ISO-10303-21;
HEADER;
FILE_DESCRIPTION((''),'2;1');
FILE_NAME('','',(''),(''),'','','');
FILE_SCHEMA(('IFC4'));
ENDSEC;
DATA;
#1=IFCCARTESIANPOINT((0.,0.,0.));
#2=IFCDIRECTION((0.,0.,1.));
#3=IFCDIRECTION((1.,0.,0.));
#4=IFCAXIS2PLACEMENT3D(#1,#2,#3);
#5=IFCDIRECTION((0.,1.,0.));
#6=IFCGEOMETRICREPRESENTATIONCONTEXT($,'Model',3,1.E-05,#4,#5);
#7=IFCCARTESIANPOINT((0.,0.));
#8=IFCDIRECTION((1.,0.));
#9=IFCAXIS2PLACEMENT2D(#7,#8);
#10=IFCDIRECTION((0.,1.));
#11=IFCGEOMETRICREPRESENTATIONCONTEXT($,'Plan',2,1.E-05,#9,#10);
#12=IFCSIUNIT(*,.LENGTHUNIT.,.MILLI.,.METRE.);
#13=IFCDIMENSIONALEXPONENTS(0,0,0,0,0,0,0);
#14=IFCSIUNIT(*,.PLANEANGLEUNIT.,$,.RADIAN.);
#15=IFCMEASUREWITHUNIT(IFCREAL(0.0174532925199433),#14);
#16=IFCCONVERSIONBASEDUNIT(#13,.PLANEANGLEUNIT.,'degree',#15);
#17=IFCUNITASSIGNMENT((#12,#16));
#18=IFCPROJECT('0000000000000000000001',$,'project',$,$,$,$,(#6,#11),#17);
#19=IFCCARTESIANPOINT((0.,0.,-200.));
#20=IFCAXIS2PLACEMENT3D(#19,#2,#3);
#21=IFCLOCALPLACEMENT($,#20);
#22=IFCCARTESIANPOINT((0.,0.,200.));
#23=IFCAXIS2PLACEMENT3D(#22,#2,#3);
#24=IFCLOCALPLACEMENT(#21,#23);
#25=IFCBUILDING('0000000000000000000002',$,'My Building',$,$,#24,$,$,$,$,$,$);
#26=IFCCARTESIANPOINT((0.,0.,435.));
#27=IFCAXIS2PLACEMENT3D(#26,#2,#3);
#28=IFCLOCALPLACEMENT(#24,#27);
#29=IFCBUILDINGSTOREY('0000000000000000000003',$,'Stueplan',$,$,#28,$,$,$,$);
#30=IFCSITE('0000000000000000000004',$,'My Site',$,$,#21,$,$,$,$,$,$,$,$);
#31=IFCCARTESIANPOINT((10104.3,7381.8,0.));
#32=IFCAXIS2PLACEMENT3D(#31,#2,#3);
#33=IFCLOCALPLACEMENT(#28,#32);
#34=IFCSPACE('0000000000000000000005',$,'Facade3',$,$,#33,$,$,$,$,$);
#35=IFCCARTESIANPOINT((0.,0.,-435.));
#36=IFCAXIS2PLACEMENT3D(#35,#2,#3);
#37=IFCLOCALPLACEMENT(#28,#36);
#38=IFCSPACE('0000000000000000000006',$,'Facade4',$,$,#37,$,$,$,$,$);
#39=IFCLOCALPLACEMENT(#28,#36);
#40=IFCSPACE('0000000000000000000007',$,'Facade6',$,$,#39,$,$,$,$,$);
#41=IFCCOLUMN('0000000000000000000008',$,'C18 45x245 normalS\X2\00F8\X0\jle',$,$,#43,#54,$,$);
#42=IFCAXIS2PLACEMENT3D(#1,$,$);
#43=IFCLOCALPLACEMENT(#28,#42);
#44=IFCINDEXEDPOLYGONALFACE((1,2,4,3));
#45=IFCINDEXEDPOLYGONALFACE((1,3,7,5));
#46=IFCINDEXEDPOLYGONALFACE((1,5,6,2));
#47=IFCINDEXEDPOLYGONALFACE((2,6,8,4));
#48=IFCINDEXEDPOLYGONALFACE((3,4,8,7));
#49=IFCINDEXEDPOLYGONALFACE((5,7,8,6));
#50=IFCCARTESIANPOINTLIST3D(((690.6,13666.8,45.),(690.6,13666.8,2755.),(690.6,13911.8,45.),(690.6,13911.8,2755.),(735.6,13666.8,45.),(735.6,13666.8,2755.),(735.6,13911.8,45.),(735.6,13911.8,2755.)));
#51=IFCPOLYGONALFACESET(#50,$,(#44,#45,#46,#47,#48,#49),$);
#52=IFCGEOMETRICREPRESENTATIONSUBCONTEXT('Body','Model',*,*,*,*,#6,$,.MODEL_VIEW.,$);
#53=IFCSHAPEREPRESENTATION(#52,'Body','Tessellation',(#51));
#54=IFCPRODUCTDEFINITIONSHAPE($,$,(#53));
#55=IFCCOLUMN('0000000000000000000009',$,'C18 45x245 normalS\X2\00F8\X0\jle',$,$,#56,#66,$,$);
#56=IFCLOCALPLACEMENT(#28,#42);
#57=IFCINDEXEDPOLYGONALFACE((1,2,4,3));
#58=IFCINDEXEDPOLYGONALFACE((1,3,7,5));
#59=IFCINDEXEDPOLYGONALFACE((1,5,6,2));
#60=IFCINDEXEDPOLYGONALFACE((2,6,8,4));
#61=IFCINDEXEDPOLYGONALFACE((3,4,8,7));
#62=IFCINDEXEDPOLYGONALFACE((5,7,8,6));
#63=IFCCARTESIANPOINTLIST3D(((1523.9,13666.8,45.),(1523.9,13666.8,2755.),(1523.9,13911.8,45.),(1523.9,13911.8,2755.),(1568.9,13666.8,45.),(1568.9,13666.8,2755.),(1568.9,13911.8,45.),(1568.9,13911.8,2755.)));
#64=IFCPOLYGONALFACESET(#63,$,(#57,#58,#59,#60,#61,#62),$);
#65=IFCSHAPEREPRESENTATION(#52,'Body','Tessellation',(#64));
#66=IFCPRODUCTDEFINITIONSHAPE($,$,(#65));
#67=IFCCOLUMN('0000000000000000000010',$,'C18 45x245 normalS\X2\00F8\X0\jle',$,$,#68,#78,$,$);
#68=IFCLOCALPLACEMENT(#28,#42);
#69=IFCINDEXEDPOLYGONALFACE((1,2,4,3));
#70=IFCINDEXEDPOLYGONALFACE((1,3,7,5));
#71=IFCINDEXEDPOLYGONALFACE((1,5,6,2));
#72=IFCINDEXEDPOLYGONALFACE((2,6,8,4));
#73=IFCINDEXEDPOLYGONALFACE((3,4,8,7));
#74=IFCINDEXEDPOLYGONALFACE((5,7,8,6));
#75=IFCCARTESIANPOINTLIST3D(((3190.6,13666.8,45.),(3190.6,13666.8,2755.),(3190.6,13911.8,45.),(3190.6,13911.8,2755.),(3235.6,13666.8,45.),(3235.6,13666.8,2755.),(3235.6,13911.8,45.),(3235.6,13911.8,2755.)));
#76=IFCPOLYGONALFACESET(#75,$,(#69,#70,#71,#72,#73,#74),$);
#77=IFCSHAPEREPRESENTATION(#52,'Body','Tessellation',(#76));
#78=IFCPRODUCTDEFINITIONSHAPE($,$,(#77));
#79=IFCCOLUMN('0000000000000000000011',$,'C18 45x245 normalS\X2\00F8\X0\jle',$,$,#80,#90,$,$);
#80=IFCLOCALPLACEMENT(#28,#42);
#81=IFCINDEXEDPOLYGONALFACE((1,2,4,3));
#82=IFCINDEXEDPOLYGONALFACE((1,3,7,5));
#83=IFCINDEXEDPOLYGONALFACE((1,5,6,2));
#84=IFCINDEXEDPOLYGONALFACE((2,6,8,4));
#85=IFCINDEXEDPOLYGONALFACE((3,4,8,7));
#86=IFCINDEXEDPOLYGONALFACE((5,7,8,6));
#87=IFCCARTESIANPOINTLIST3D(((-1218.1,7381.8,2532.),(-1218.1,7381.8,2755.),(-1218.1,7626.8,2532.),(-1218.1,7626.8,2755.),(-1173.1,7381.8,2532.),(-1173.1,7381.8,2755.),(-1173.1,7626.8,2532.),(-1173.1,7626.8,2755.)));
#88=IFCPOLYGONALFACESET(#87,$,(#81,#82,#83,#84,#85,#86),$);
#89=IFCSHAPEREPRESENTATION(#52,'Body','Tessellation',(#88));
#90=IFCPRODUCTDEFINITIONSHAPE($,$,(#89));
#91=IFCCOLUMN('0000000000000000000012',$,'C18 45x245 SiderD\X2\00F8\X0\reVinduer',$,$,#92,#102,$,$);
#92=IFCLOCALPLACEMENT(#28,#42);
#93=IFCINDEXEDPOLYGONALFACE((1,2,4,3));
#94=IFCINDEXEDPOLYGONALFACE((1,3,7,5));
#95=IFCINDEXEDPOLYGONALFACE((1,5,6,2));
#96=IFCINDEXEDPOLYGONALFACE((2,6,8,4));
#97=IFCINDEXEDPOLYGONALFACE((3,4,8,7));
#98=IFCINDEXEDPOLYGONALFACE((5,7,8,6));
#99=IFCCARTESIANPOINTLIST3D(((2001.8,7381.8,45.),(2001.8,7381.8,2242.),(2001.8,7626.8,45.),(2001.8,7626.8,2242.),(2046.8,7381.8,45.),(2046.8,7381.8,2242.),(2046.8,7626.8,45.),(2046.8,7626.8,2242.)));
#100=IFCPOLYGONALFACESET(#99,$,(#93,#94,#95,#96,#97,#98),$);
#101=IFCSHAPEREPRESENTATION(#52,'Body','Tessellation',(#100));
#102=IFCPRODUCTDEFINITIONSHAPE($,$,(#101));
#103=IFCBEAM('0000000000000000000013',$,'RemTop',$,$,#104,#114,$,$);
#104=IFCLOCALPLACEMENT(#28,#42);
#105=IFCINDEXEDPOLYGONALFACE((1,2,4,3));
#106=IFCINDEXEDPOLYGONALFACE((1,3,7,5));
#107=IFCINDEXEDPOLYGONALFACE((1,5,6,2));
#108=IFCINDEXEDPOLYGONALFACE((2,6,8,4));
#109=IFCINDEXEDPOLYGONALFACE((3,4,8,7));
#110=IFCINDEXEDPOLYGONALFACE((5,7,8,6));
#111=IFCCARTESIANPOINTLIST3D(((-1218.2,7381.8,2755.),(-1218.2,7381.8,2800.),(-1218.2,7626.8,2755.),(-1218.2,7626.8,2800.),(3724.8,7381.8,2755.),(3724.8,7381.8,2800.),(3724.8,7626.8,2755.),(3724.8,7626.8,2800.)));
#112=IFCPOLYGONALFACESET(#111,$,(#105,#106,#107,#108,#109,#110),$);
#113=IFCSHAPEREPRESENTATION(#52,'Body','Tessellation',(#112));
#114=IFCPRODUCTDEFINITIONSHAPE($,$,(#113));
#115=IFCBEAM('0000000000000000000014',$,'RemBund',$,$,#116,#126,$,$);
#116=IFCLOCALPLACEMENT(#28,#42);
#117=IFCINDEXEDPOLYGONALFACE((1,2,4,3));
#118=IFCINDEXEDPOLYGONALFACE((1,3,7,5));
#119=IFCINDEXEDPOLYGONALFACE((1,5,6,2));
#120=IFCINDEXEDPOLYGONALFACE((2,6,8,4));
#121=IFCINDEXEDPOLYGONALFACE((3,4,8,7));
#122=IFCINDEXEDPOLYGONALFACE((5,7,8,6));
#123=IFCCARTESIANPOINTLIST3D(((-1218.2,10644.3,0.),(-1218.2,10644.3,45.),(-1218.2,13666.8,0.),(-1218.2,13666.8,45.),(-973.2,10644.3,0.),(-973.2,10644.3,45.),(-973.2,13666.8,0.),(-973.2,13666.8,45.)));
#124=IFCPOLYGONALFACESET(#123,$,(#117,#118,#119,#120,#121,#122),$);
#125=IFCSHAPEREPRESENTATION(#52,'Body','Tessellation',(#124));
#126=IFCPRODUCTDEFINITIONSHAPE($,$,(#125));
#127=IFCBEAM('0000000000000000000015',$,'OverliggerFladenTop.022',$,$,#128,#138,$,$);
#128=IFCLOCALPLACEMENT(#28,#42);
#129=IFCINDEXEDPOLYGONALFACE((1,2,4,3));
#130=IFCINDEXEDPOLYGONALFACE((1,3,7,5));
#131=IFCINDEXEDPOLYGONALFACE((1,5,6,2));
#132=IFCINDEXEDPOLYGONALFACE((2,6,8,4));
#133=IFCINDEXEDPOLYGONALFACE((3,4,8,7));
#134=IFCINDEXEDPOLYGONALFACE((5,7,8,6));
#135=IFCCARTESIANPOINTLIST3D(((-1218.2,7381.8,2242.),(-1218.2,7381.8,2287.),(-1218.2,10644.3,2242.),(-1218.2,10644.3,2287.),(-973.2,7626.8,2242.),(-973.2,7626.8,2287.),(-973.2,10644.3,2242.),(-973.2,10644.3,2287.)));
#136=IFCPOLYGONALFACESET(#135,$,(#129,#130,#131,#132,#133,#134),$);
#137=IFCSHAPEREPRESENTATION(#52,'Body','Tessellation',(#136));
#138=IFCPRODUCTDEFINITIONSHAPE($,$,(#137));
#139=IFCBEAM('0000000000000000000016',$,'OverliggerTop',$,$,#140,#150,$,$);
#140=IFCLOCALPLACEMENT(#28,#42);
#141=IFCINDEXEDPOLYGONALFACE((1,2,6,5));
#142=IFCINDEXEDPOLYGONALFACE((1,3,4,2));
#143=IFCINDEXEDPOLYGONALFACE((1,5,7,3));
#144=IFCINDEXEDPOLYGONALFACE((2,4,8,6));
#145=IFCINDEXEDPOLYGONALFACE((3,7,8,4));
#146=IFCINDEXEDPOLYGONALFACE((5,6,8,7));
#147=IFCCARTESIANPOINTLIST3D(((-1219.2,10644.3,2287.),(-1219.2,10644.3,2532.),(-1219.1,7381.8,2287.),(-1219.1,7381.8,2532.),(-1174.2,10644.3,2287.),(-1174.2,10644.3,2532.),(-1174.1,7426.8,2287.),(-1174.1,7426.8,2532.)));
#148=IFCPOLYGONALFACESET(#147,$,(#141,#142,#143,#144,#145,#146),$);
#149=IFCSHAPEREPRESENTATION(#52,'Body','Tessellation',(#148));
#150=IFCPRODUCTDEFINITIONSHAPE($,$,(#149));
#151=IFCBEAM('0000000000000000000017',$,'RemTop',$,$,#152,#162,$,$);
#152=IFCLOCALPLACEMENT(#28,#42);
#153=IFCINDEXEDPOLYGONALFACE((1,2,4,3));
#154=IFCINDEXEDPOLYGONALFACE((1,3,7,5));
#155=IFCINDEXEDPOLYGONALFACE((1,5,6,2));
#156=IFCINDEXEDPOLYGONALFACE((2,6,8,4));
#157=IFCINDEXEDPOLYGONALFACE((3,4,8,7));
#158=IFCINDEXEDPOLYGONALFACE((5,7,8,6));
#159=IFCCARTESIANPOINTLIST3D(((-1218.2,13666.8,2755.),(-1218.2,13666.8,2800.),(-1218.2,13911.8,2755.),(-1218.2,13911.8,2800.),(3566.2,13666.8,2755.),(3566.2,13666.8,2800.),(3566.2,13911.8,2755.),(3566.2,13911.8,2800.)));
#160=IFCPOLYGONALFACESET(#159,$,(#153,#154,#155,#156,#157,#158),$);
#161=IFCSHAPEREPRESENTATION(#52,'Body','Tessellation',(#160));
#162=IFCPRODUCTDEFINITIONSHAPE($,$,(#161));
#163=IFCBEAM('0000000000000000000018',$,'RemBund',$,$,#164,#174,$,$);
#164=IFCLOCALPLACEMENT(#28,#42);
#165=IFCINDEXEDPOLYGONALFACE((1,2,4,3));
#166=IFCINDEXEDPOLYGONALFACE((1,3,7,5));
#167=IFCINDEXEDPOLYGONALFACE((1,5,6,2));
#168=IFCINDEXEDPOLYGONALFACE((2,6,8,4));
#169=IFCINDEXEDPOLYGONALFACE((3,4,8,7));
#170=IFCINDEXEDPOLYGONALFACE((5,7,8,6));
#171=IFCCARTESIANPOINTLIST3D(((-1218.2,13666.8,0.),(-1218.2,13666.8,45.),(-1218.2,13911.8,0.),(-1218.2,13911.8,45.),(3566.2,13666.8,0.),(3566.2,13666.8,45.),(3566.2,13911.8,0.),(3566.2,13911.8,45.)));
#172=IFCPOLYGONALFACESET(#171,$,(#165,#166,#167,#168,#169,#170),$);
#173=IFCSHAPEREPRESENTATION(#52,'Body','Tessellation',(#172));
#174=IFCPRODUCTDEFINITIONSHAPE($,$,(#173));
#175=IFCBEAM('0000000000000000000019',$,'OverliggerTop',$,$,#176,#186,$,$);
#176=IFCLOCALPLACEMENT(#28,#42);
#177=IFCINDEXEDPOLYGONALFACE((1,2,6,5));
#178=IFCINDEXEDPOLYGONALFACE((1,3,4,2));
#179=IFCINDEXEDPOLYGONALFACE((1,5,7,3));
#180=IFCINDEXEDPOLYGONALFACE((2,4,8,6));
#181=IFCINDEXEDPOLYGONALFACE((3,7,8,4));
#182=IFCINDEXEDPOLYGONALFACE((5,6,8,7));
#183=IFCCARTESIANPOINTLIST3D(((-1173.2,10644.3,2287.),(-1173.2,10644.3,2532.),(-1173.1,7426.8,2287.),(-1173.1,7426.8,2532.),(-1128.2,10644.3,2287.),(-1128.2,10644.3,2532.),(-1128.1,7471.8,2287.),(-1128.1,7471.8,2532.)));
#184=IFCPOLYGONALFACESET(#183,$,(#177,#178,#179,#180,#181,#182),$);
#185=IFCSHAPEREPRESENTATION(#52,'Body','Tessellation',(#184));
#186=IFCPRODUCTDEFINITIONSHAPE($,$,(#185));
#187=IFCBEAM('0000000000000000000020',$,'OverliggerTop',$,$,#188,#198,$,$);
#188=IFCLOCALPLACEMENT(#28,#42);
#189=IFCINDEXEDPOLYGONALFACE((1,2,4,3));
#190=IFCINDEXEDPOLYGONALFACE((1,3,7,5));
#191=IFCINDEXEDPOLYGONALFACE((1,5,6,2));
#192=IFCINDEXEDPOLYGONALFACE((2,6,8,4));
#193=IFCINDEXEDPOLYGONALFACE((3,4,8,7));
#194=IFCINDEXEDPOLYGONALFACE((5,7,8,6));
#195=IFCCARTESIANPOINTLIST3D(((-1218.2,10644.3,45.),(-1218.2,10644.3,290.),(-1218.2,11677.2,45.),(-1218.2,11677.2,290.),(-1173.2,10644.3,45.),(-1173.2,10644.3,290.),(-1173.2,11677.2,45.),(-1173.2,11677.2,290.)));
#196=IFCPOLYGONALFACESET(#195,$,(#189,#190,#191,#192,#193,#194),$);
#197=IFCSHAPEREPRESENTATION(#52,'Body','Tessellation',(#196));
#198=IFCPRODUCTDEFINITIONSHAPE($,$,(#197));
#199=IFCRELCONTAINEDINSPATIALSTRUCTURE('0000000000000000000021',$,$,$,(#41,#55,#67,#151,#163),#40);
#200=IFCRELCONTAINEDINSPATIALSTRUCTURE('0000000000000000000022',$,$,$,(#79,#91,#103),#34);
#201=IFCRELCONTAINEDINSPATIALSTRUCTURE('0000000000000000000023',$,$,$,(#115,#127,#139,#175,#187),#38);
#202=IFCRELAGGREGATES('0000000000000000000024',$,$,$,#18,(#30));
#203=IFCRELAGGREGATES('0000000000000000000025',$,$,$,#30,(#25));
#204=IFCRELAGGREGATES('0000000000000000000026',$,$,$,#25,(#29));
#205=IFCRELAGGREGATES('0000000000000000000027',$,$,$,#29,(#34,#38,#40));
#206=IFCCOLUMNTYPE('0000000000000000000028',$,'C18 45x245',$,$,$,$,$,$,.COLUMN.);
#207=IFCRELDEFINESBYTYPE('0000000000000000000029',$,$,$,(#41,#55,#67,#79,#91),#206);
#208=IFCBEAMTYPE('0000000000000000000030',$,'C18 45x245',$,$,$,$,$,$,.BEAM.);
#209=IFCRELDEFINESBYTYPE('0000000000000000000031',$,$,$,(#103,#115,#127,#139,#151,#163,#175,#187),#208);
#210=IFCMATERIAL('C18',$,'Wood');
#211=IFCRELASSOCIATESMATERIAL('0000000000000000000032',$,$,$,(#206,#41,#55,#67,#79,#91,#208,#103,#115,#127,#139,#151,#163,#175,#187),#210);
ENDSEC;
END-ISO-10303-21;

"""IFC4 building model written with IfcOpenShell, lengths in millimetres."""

from ifc_helpers import new_model, entity, si_unit, converted_unit, direction, frame, origin_with_axes, origin_2d_with_axis, place, context, subcontext, project, spatial, rectangle, extrude, clip, halfspace, material, material_profile, profile_set, profile_usage, type_object, element, save


model = new_model("IFC4")

# Units and contexts
model_context = context("Model", 3, precision=1e-05, world=origin_with_axes(), true_north=direction((0.0, 1.0, 0.0)))
plan_context = context("Plan", 2, precision=1e-05, world=origin_2d_with_axis(), true_north=direction((0.0, 1.0)))
body_context_1 = subcontext(model_context, "Body", "Model", "MODEL_VIEW")
ifc_project = project(units=[si_unit("LENGTHUNIT", "METRE", prefix="MILLI"), converted_unit("PLANEANGLEUNIT", "degree", entity("IfcReal", 0.0174532925199433), si_unit("PLANEANGLEUNIT", "RADIAN"), dimensions=[0, 0, 0, 0, 0, 0, 0])], contexts=[model_context, plan_context])

# Site, building, storey, space
site_placement = place(None, frame((0.0, 0.0, -200.0), z_axis=(0.0, 0.0, 1.0), x_axis=(1.0, 0.0, 0.0)))
site = spatial("IfcSite", under=ifc_project, at=site_placement, Name="My Site")
building_placement = place(site_placement, frame((0.0, 0.0, 200.0), z_axis=(0.0, 0.0, 1.0), x_axis=(1.0, 0.0, 0.0)))
building = spatial("IfcBuilding", under=site, at=building_placement, Name="My Building")
storey_placement = place(building_placement, frame((0.0, 0.0, 435.0), z_axis=(0.0, 0.0, 1.0), x_axis=(1.0, 0.0, 0.0)))
storey = spatial("IfcBuildingStorey", under=building, at=storey_placement, Name="Stueplan")
space_1_placement = place(storey_placement, frame((10104.3, 7381.8, 0.0), z_axis=(0.0, 0.0, 1.0), x_axis=(1.0, 0.0, 0.0)))
space_1 = spatial("IfcSpace", under=storey, at=space_1_placement, Name="Facade3")

# Shared definitions
ifc_material_1 = material(Name="C18", Category="Wood")
ifc_material_profile_1 = material_profile(ifc_material_1, rectangle(XDim=45.0, YDim=245.0))
ifc_profile_set_1 = profile_set([ifc_material_profile_1], Name="woodStructural")
column_type = type_object("IfcColumnType", Name="C18 45x245", PredefinedType="COLUMN", material=ifc_profile_set_1)

# Shared definitions
space_2_placement = place(storey_placement, frame((0.0, 0.0, -435.0), z_axis=(0.0, 0.0, 1.0), x_axis=(1.0, 0.0, 0.0)))
space_2 = spatial("IfcSpace", under=storey, at=space_2_placement, Name="Facade4")

# Shared definitions
space_3_placement = place(storey_placement, frame((0.0, 0.0, -435.0), z_axis=(0.0, 0.0, 1.0), x_axis=(1.0, 0.0, 0.0)))
space_3 = spatial("IfcSpace", under=storey, at=space_3_placement, Name="Facade6")

# Columns
ifc_profile_usage_1 = profile_usage(ifc_profile_set_1, cardinal=9)
column_1_placement = place(space_3_placement, frame((690.6, 13911.8, 480.0), z_axis=(0.0, 0.0, 1.0), x_axis=(1.0, 0.0, 0.0)))
element("IfcColumn", 1, at=column_1_placement, inside=space_3, type_object=column_type, material=ifc_profile_usage_1, Name="C18 45x245 normalSøjle", context=body_context_1, shape_type="SweptSolid", body=[
    extrude(rectangle(XDim=45.0, YDim=245.0), frame((22.5, -122.5, 0.0), z_axis=(0.0, 0.0, 1.0), x_axis=(1.0, 0.0, 0.0)), (0.0, 0.0, 1.0), 2710.0),
])
ifc_profile_usage_2 = profile_usage(ifc_profile_set_1, cardinal=9)
column_2_placement = place(space_3_placement, frame((1523.9, 13911.8, 480.0), z_axis=(0.0, 0.0, 1.0), x_axis=(1.0, 0.0, 0.0)))
element("IfcColumn", 2, at=column_2_placement, inside=space_3, type_object=column_type, material=ifc_profile_usage_2, Name="C18 45x245 normalSøjle", context=body_context_1, shape_type="SweptSolid", body=[
    extrude(rectangle(XDim=45.0, YDim=245.0), frame((22.5, -122.5, 0.0), z_axis=(0.0, 0.0, 1.0), x_axis=(1.0, 0.0, 0.0)), (0.0, 0.0, 1.0), 2710.0),
])
ifc_profile_usage_3 = profile_usage(ifc_profile_set_1, cardinal=9)
column_3_placement = place(space_3_placement, frame((3190.6, 13911.8, 480.0), z_axis=(0.0, 0.0, 1.0), x_axis=(1.0, 0.0, 0.0)))
element("IfcColumn", 3, at=column_3_placement, inside=space_3, type_object=column_type, material=ifc_profile_usage_3, Name="C18 45x245 normalSøjle", context=body_context_1, shape_type="SweptSolid", body=[
    extrude(rectangle(XDim=45.0, YDim=245.0), frame((22.5, -122.5, 0.0), z_axis=(0.0, 0.0, 1.0), x_axis=(1.0, 0.0, 0.0)), (0.0, 0.0, 1.0), 2710.0),
])
ifc_profile_usage_4 = profile_usage(ifc_profile_set_1, cardinal=9)
column_4_placement = place(space_1_placement, frame((-11322.5, 245.0, 2532.0), z_axis=(0.0, 0.0, 1.0), x_axis=(1.0, 0.0, 0.0)))
element("IfcColumn", 4, at=column_4_placement, inside=space_1, type_object=column_type, material=ifc_profile_usage_4, Name="C18 45x245 normalSøjle", context=body_context_1, shape_type="SweptSolid", body=[
    extrude(rectangle(XDim=45.0, YDim=245.0), frame((22.5, -122.5, 0.0), z_axis=(0.0, 0.0, 1.0), x_axis=(1.0, 0.0, 0.0)), (0.0, 0.0, 1.0), 223.0),
])
ifc_profile_usage_5 = profile_usage(ifc_profile_set_1, cardinal=9)
column_5_placement = place(space_1_placement, frame((-8102.5, 245.0, 45.0), z_axis=(0.0, 0.0, 1.0), x_axis=(1.0, 0.0, 0.0)))
element("IfcColumn", 5, at=column_5_placement, inside=space_1, type_object=column_type, material=ifc_profile_usage_5, Name="C18 45x245 SiderDøreVinduer", context=body_context_1, shape_type="SweptSolid", body=[
    extrude(rectangle(XDim=45.0, YDim=245.0), frame((22.5, -122.5, 0.0), z_axis=(0.0, 0.0, 1.0), x_axis=(1.0, 0.0, 0.0)), (0.0, 0.0, 1.0), 2197.0),
])

# Beams
ifc_material_profile_2 = material_profile(ifc_material_1, rectangle(XDim=45.0, YDim=245.0), Name="concrete")
ifc_profile_set_2 = profile_set([ifc_material_profile_2], Name="woodStructural")
ifc_profile_usage_6 = profile_usage(ifc_profile_set_2)
beam_type = type_object("IfcBeamType", Name="C18 45x245", PredefinedType="BEAM", material=ifc_profile_set_2)
beam_1_placement = place(space_1_placement, frame((-6379.6, 122.5, 2777.5), z_axis=(-1.0, 0.0, 0.0), x_axis=(0.0, 0.0, 1.0)))
element("IfcBeam", 6, at=beam_1_placement, inside=space_1, type_object=beam_type, material=ifc_profile_usage_6, Name="RemTop", context=body_context_1, shape_type="SweptSolid", body=[
    extrude(rectangle(XDim=45.0, YDim=245.0), origin_with_axes(), (0.0, 0.0, 1.0), 4942.9),
])
ifc_profile_usage_7 = profile_usage(ifc_profile_set_2)
beam_2_placement = place(space_2_placement, frame((-1095.7, 13666.8, 457.5), z_axis=(0.0, -1.0, 0.0), x_axis=(0.0, 0.0, 1.0)))
element("IfcBeam", 7, at=beam_2_placement, inside=space_2, type_object=beam_type, material=ifc_profile_usage_7, Name="RemBund", context=body_context_1, shape_type="SweptSolid", body=[
    extrude(rectangle(XDim=45.0, YDim=245.0), origin_with_axes(), (0.0, 0.0, 1.0), 3022.5),
])
ifc_profile_usage_8 = profile_usage(ifc_profile_set_2)
beam_3_placement = place(space_2_placement, frame((-1095.7, 10644.3, 2699.5), z_axis=(0.0, -1.0, 0.0), x_axis=(0.0, 0.0, 1.0)))
element("IfcBeam", 8, at=beam_3_placement, inside=space_2, type_object=beam_type, material=ifc_profile_usage_8, Name="OverliggerFladenTop.022", context=body_context_1, shape_type="Clipping", body=[
    clip(extrude(rectangle(XDim=45.0, YDim=245.0), origin_with_axes(), (0.0, 0.0, 1.0), 3262.5), halfspace(frame((-2699.5, 122.5, 3262.5), z_axis=(0.0, -0.707107, 0.707107), x_axis=(-1.0, 0.0, 0.0)), False)),
])
ifc_profile_usage_9 = profile_usage(ifc_profile_set_2)
beam_4_placement = place(space_2_placement, frame((-1196.7, 10644.3, 2844.5), z_axis=(0.0, -1.0, 0.0), x_axis=(-1.0, 0.0, 0.0)))
element("IfcBeam", 9, at=beam_4_placement, inside=space_2, type_object=beam_type, material=ifc_profile_usage_9, Name="OverliggerTop", context=body_context_1, shape_type="Clipping", body=[
    clip(extrude(rectangle(XDim=45.0, YDim=245.0), origin_with_axes(), (0.0, 0.0, 1.0), 3262.5), halfspace(frame((22.5, 2844.5, 3262.5), z_axis=(-0.707107, 0.0, 0.707107), x_axis=(0.0, 1.0, 0.0)), False)),
])
ifc_profile_usage_10 = profile_usage(ifc_profile_set_2)
beam_5_placement = place(space_3_placement, frame((3566.2, 13789.3, 3212.5), z_axis=(-1.0, 0.0, 0.0), x_axis=(0.0, 0.0, 1.0)))
element("IfcBeam", 10, at=beam_5_placement, inside=space_3, type_object=beam_type, material=ifc_profile_usage_10, Name="RemTop", context=body_context_1, shape_type="SweptSolid", body=[
    extrude(rectangle(XDim=45.0, YDim=245.0), origin_with_axes(), (0.0, 0.0, 1.0), 4784.4),
])
ifc_profile_usage_11 = profile_usage(ifc_profile_set_2)
beam_6_placement = place(space_3_placement, frame((3566.2, 13789.3, 457.5), z_axis=(-1.0, 0.0, 0.0), x_axis=(0.0, 0.0, 1.0)))
element("IfcBeam", 11, at=beam_6_placement, inside=space_3, type_object=beam_type, material=ifc_profile_usage_11, Name="RemBund", context=body_context_1, shape_type="SweptSolid", body=[
    extrude(rectangle(XDim=45.0, YDim=245.0), origin_with_axes(), (0.0, 0.0, 1.0), 4784.4),
])
ifc_profile_usage_12 = profile_usage(ifc_profile_set_2)
beam_7_placement = place(space_2_placement, frame((-1150.7, 10644.3, 2844.5), z_axis=(0.0, -1.0, 0.0), x_axis=(-1.0, 0.0, 0.0)))
element("IfcBeam", 12, at=beam_7_placement, inside=space_2, type_object=beam_type, material=ifc_profile_usage_12, Name="OverliggerTop", context=body_context_1, shape_type="Clipping", body=[
    clip(extrude(rectangle(XDim=45.0, YDim=245.0), origin_with_axes(), (0.0, 0.0, 1.0), 3217.5), halfspace(frame((22.5, 2844.5, 3217.5), z_axis=(-0.70711, 0.0, 0.707103), x_axis=(0.0, 1.0, 0.0)), False)),
])
ifc_profile_usage_13 = profile_usage(ifc_profile_set_2)
beam_8_placement = place(space_2_placement, frame((-1195.7, 11677.2, 602.5), z_axis=(0.0, -1.0, 0.0), x_axis=(-1.0, 0.0, 0.0)))
element("IfcBeam", 13, at=beam_8_placement, inside=space_2, type_object=beam_type, material=ifc_profile_usage_13, Name="OverliggerTop", context=body_context_1, shape_type="SweptSolid", body=[
    extrude(rectangle(XDim=45.0, YDim=245.0), origin_with_axes(), (0.0, 0.0, 1.0), 1032.9),
])

save(model, "model.ifc")
